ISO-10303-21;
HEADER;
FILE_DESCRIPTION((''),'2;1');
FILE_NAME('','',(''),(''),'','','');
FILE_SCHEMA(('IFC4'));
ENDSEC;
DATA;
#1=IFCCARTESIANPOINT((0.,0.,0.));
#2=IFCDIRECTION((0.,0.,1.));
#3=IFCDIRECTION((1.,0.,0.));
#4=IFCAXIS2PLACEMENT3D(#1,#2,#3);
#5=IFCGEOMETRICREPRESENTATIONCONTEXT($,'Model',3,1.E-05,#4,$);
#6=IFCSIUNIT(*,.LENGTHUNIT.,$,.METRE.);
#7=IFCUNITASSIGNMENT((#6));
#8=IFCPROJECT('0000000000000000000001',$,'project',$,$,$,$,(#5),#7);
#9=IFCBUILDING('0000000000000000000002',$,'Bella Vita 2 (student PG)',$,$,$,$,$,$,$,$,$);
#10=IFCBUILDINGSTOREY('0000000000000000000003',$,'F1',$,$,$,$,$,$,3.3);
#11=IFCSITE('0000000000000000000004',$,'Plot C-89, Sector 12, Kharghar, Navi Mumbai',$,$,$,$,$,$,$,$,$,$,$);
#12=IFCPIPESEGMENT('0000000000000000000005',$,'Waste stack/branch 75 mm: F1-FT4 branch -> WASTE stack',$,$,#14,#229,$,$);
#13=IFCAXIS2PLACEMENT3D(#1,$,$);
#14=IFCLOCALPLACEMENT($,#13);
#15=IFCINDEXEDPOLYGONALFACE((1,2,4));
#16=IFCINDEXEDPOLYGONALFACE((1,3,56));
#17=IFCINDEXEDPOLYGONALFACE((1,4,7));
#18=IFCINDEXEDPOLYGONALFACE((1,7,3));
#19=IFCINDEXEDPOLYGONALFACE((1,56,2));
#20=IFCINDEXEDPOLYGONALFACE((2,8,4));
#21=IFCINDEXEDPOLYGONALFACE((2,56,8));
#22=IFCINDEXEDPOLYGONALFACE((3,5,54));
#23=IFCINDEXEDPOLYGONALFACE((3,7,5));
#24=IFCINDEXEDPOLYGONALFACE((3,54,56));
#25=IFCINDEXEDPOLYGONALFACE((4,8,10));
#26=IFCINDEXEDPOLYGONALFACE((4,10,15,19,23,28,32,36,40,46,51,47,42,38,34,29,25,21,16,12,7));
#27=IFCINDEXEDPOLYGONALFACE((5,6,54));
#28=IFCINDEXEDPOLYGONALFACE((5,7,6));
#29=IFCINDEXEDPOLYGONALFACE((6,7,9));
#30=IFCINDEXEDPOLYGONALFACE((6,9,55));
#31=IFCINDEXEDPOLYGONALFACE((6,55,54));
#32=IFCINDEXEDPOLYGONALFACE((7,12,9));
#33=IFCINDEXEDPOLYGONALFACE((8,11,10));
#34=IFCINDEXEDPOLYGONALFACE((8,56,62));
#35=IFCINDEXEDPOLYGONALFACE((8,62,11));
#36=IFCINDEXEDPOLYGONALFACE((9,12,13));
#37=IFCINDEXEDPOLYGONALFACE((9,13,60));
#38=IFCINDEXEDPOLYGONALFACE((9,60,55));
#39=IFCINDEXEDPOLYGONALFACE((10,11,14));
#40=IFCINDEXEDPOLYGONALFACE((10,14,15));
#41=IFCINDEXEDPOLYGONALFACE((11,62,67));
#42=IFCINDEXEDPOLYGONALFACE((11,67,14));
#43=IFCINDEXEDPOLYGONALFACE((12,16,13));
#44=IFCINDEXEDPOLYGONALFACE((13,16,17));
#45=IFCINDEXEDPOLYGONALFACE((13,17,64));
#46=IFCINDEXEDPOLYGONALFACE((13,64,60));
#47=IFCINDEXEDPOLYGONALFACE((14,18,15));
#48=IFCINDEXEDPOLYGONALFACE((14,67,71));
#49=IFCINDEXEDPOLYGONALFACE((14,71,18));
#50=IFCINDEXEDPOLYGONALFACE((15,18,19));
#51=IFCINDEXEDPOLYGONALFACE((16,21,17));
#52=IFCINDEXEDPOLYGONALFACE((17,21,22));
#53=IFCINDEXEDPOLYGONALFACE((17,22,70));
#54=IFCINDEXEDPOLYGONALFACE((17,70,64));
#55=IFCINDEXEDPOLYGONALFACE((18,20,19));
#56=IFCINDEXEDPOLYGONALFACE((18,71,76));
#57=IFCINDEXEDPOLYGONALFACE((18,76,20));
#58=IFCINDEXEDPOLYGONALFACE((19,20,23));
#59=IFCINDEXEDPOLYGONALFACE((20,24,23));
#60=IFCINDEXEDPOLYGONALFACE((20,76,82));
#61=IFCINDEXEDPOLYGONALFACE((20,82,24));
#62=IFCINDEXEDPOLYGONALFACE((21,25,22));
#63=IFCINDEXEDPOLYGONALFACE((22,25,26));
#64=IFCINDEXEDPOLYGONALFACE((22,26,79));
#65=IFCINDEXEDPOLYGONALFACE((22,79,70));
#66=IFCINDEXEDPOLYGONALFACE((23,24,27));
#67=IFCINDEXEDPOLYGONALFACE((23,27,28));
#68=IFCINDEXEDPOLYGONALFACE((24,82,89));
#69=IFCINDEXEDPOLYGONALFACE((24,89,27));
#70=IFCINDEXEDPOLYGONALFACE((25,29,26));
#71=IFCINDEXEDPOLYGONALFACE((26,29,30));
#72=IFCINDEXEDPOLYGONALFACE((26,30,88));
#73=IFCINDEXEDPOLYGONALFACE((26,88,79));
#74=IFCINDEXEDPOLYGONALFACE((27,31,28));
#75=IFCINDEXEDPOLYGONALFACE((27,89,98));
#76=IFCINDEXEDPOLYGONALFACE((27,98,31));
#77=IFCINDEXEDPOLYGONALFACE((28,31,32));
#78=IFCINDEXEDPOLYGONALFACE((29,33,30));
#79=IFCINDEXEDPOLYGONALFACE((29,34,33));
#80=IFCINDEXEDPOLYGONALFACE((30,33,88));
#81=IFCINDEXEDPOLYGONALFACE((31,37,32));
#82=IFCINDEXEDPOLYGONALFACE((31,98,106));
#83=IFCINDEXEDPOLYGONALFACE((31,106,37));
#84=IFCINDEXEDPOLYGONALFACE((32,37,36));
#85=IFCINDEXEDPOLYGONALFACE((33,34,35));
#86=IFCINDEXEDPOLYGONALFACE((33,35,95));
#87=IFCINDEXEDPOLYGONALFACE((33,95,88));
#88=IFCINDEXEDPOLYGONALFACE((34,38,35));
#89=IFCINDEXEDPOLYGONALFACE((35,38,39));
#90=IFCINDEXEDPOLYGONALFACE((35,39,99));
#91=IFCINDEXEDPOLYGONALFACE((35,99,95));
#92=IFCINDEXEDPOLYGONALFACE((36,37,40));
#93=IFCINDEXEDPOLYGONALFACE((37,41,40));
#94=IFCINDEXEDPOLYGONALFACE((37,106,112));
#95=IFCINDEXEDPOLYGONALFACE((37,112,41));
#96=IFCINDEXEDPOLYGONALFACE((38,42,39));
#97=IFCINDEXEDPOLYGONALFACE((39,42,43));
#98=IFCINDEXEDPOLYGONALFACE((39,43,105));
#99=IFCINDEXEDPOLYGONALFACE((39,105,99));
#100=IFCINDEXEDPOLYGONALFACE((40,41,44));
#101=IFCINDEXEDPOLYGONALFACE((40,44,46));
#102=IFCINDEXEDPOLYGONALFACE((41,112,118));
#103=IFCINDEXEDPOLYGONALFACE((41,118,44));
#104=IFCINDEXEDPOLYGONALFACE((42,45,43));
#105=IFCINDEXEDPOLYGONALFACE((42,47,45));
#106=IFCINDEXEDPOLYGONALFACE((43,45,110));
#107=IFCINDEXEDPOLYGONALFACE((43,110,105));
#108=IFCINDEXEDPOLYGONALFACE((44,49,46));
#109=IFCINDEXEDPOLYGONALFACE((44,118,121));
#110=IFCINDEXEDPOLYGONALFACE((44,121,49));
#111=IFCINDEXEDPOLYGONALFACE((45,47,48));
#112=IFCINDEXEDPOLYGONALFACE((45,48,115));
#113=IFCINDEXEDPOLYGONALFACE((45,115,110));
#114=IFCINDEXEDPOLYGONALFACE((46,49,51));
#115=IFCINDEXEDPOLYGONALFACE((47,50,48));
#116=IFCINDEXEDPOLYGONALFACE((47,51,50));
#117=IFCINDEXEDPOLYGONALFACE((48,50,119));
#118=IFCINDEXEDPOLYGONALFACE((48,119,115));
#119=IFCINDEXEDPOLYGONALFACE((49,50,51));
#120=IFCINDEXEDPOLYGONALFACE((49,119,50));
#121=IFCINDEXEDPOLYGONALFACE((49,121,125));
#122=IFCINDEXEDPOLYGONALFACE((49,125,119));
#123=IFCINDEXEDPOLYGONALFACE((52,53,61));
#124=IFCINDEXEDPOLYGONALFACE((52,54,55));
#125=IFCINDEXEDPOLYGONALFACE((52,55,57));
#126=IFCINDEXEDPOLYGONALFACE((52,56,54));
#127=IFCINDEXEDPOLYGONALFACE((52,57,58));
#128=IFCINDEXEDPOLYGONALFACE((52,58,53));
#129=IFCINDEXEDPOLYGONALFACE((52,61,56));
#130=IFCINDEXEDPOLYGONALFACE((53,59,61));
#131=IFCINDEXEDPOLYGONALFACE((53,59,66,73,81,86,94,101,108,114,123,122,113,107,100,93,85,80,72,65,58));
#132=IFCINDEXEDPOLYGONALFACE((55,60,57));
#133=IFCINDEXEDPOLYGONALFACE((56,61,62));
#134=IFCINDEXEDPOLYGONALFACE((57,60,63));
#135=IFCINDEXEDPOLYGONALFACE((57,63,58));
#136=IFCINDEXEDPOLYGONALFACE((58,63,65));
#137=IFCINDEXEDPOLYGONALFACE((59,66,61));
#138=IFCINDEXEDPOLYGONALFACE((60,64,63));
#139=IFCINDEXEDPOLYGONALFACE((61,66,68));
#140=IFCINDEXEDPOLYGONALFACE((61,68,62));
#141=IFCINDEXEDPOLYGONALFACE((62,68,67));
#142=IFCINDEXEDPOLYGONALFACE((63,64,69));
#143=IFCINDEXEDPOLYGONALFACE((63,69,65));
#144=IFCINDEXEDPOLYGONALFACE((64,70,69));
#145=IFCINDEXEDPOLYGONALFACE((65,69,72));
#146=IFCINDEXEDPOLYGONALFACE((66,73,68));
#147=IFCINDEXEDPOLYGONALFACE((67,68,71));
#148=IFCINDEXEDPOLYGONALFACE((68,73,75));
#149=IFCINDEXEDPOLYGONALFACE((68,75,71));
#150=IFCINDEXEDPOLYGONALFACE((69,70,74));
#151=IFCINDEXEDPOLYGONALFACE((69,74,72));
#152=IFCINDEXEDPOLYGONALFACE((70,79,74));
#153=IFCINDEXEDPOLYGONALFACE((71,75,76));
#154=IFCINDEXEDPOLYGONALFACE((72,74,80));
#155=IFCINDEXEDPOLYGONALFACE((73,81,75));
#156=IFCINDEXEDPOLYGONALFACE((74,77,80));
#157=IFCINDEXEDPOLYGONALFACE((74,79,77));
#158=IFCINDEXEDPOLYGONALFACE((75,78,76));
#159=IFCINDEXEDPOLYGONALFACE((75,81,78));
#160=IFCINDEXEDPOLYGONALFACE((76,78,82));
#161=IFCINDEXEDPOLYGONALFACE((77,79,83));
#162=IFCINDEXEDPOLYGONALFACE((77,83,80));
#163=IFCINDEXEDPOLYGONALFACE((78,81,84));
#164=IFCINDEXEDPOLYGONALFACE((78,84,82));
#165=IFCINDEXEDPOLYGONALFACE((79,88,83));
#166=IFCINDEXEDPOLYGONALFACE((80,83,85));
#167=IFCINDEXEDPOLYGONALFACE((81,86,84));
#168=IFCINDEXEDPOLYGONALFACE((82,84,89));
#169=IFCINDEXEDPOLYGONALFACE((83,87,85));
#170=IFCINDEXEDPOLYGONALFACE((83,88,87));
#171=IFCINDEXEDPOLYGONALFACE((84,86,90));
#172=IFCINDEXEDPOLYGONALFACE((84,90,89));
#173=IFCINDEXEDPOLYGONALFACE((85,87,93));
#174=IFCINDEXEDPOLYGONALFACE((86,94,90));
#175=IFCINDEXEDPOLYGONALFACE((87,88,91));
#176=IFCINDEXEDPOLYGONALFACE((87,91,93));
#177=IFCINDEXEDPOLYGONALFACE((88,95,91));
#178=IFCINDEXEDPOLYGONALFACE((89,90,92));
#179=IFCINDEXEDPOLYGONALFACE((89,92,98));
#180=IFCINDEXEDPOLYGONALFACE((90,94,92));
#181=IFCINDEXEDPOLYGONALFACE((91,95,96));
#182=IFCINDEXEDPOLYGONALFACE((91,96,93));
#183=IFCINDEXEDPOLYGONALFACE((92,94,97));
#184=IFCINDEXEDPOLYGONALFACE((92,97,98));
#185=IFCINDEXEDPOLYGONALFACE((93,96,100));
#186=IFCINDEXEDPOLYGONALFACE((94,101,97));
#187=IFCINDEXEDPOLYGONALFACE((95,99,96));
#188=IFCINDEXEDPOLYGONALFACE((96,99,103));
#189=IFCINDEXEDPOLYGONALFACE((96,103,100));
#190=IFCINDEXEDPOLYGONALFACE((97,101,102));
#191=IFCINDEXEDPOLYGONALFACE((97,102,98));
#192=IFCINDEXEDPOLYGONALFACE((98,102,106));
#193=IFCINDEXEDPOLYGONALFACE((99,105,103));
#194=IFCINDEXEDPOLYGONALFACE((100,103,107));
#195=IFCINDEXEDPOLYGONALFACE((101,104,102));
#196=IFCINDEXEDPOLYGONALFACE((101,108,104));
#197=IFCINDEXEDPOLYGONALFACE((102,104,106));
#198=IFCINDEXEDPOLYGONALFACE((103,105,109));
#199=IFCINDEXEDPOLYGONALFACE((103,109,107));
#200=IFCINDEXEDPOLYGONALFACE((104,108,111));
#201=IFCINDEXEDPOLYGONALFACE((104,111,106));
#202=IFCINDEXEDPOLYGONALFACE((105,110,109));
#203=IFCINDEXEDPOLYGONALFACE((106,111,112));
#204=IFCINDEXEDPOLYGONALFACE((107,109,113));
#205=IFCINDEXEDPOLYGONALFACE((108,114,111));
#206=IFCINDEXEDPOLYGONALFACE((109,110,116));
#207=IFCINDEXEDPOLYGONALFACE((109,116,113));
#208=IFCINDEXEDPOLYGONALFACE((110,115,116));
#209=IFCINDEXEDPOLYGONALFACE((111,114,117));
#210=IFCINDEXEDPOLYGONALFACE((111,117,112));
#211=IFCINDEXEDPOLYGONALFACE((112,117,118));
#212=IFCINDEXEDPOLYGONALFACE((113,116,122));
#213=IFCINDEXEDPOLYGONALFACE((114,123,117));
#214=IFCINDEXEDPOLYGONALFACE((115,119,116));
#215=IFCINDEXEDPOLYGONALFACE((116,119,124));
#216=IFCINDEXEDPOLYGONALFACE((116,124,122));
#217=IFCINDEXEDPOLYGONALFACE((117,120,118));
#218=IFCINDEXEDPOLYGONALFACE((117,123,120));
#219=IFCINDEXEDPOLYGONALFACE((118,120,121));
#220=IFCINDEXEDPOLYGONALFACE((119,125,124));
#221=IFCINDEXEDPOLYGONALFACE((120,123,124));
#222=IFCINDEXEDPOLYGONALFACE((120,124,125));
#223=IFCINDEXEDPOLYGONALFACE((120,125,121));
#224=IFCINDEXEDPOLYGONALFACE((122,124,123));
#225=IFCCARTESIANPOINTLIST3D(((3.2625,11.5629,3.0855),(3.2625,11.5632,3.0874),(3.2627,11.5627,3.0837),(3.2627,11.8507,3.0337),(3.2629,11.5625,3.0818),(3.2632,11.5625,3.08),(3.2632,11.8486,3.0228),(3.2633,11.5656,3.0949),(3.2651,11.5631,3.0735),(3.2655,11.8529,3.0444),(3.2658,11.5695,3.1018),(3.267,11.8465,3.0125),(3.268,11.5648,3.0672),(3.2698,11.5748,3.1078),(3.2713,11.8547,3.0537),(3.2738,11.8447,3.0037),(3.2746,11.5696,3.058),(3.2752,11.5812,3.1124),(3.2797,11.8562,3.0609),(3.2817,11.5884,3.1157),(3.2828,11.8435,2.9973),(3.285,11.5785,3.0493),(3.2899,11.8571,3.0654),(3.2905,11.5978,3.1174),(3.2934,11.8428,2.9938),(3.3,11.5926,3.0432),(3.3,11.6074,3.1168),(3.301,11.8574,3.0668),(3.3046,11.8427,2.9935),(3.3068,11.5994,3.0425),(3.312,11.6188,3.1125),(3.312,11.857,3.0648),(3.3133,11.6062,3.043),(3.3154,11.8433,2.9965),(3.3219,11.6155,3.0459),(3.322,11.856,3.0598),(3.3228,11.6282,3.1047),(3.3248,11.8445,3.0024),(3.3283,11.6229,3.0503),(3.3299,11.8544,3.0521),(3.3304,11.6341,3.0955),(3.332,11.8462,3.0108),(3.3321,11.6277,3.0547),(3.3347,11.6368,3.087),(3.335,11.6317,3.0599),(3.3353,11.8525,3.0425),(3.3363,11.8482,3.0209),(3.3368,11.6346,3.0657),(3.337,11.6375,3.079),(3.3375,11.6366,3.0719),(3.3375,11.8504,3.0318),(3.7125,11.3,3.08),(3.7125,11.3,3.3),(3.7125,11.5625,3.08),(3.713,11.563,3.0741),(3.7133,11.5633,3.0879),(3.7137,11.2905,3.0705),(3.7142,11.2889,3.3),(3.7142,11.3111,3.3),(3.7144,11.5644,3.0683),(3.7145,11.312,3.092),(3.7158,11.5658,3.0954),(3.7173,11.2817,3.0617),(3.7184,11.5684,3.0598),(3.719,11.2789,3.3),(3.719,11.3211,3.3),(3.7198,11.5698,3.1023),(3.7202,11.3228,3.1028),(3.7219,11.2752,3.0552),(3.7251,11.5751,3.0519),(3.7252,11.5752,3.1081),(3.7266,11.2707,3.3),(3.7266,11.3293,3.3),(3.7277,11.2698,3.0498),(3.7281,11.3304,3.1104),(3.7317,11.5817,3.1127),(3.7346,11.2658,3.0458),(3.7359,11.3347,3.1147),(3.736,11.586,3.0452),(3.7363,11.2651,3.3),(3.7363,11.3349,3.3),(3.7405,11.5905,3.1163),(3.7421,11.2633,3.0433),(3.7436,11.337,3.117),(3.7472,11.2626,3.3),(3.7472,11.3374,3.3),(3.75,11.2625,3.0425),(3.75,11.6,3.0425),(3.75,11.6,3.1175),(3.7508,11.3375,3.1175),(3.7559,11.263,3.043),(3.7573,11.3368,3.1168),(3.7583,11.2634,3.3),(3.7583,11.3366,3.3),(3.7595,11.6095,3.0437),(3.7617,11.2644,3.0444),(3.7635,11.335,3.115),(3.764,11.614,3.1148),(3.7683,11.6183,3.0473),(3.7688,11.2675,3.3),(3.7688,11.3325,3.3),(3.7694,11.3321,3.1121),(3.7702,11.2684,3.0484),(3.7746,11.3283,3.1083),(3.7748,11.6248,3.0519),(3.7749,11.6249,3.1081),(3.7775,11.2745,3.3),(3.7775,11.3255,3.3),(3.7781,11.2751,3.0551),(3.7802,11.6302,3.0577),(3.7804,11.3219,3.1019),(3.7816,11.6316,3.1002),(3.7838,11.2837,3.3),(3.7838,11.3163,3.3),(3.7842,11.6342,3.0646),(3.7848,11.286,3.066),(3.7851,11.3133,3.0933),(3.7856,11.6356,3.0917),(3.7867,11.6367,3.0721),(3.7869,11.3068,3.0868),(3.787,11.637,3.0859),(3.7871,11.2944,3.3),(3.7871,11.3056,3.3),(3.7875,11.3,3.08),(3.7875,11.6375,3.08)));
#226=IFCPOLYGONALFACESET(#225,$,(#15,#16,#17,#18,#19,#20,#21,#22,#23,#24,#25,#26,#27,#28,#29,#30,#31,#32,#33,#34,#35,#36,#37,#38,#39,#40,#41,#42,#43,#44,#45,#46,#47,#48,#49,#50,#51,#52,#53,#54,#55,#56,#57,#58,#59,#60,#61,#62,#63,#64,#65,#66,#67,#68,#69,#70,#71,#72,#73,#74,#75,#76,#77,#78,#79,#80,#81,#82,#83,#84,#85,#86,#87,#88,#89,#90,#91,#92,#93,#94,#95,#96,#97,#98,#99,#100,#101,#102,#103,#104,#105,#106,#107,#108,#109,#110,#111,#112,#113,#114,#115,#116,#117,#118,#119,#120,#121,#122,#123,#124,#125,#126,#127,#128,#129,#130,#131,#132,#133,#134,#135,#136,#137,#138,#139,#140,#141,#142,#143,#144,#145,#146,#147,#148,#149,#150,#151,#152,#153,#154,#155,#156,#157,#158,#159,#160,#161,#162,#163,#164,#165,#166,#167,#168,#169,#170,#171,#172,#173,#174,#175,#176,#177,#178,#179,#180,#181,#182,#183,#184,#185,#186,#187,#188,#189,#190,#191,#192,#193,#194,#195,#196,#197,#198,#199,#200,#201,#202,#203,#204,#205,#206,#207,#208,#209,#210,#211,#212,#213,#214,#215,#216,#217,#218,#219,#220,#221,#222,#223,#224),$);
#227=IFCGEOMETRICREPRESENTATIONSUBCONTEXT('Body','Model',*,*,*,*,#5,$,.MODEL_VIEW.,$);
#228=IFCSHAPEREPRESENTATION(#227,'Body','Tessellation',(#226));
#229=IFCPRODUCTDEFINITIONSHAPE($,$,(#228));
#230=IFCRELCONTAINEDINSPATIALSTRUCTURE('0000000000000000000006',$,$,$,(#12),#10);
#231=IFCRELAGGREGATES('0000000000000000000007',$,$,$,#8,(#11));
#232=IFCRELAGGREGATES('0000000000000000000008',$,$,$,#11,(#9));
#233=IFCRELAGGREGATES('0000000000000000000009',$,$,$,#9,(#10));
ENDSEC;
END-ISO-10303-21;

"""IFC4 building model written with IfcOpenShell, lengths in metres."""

from ifc_helpers import new_model, entity, si_unit, origin, origin_with_axes, place, context, subcontext, project, spatial, element, save


model = new_model("IFC4")

# Units and contexts
model_context = context("Model", 3, precision=1e-05, world=origin_with_axes())
body_context = subcontext(model_context, "Body", "Model", "MODEL_VIEW")
ifc_project = project(units=[si_unit("LENGTHUNIT", "METRE")], contexts=[model_context])

# Site, building, storey
site = spatial("IfcSite", under=ifc_project, Name="Plot C-89, Sector 12, Kharghar, Navi Mumbai")
building = spatial("IfcBuilding", under=site, Name="Bella Vita 2 (student PG)")
storey = spatial("IfcBuildingStorey", under=building, Name="F1", Elevation=3.3)

# Pipe segment
pipe_segment_1_placement = place(None, origin())
element("IfcPipeSegment", 1, at=pipe_segment_1_placement, inside=storey, Name="Waste stack/branch 75 mm: F1-FT4 branch -> WASTE stack", context=body_context, shape_type="AdvancedSweptSolid", body=[
    entity("IfcSweptDiskSolid", entity("IfcPolyline", [entity("IfcCartesianPoint", [3.75, 11.3, 3.3]), entity("IfcCartesianPoint", [3.75, 11.3, 3.08]), entity("IfcCartesianPoint", [3.75, 11.6, 3.08]), entity("IfcCartesianPoint", [3.3, 11.6, 3.08]), entity("IfcCartesianPoint", [3.3, 11.85, 3.03])]), 0.0375),
])

save(model, "model.ifc")
